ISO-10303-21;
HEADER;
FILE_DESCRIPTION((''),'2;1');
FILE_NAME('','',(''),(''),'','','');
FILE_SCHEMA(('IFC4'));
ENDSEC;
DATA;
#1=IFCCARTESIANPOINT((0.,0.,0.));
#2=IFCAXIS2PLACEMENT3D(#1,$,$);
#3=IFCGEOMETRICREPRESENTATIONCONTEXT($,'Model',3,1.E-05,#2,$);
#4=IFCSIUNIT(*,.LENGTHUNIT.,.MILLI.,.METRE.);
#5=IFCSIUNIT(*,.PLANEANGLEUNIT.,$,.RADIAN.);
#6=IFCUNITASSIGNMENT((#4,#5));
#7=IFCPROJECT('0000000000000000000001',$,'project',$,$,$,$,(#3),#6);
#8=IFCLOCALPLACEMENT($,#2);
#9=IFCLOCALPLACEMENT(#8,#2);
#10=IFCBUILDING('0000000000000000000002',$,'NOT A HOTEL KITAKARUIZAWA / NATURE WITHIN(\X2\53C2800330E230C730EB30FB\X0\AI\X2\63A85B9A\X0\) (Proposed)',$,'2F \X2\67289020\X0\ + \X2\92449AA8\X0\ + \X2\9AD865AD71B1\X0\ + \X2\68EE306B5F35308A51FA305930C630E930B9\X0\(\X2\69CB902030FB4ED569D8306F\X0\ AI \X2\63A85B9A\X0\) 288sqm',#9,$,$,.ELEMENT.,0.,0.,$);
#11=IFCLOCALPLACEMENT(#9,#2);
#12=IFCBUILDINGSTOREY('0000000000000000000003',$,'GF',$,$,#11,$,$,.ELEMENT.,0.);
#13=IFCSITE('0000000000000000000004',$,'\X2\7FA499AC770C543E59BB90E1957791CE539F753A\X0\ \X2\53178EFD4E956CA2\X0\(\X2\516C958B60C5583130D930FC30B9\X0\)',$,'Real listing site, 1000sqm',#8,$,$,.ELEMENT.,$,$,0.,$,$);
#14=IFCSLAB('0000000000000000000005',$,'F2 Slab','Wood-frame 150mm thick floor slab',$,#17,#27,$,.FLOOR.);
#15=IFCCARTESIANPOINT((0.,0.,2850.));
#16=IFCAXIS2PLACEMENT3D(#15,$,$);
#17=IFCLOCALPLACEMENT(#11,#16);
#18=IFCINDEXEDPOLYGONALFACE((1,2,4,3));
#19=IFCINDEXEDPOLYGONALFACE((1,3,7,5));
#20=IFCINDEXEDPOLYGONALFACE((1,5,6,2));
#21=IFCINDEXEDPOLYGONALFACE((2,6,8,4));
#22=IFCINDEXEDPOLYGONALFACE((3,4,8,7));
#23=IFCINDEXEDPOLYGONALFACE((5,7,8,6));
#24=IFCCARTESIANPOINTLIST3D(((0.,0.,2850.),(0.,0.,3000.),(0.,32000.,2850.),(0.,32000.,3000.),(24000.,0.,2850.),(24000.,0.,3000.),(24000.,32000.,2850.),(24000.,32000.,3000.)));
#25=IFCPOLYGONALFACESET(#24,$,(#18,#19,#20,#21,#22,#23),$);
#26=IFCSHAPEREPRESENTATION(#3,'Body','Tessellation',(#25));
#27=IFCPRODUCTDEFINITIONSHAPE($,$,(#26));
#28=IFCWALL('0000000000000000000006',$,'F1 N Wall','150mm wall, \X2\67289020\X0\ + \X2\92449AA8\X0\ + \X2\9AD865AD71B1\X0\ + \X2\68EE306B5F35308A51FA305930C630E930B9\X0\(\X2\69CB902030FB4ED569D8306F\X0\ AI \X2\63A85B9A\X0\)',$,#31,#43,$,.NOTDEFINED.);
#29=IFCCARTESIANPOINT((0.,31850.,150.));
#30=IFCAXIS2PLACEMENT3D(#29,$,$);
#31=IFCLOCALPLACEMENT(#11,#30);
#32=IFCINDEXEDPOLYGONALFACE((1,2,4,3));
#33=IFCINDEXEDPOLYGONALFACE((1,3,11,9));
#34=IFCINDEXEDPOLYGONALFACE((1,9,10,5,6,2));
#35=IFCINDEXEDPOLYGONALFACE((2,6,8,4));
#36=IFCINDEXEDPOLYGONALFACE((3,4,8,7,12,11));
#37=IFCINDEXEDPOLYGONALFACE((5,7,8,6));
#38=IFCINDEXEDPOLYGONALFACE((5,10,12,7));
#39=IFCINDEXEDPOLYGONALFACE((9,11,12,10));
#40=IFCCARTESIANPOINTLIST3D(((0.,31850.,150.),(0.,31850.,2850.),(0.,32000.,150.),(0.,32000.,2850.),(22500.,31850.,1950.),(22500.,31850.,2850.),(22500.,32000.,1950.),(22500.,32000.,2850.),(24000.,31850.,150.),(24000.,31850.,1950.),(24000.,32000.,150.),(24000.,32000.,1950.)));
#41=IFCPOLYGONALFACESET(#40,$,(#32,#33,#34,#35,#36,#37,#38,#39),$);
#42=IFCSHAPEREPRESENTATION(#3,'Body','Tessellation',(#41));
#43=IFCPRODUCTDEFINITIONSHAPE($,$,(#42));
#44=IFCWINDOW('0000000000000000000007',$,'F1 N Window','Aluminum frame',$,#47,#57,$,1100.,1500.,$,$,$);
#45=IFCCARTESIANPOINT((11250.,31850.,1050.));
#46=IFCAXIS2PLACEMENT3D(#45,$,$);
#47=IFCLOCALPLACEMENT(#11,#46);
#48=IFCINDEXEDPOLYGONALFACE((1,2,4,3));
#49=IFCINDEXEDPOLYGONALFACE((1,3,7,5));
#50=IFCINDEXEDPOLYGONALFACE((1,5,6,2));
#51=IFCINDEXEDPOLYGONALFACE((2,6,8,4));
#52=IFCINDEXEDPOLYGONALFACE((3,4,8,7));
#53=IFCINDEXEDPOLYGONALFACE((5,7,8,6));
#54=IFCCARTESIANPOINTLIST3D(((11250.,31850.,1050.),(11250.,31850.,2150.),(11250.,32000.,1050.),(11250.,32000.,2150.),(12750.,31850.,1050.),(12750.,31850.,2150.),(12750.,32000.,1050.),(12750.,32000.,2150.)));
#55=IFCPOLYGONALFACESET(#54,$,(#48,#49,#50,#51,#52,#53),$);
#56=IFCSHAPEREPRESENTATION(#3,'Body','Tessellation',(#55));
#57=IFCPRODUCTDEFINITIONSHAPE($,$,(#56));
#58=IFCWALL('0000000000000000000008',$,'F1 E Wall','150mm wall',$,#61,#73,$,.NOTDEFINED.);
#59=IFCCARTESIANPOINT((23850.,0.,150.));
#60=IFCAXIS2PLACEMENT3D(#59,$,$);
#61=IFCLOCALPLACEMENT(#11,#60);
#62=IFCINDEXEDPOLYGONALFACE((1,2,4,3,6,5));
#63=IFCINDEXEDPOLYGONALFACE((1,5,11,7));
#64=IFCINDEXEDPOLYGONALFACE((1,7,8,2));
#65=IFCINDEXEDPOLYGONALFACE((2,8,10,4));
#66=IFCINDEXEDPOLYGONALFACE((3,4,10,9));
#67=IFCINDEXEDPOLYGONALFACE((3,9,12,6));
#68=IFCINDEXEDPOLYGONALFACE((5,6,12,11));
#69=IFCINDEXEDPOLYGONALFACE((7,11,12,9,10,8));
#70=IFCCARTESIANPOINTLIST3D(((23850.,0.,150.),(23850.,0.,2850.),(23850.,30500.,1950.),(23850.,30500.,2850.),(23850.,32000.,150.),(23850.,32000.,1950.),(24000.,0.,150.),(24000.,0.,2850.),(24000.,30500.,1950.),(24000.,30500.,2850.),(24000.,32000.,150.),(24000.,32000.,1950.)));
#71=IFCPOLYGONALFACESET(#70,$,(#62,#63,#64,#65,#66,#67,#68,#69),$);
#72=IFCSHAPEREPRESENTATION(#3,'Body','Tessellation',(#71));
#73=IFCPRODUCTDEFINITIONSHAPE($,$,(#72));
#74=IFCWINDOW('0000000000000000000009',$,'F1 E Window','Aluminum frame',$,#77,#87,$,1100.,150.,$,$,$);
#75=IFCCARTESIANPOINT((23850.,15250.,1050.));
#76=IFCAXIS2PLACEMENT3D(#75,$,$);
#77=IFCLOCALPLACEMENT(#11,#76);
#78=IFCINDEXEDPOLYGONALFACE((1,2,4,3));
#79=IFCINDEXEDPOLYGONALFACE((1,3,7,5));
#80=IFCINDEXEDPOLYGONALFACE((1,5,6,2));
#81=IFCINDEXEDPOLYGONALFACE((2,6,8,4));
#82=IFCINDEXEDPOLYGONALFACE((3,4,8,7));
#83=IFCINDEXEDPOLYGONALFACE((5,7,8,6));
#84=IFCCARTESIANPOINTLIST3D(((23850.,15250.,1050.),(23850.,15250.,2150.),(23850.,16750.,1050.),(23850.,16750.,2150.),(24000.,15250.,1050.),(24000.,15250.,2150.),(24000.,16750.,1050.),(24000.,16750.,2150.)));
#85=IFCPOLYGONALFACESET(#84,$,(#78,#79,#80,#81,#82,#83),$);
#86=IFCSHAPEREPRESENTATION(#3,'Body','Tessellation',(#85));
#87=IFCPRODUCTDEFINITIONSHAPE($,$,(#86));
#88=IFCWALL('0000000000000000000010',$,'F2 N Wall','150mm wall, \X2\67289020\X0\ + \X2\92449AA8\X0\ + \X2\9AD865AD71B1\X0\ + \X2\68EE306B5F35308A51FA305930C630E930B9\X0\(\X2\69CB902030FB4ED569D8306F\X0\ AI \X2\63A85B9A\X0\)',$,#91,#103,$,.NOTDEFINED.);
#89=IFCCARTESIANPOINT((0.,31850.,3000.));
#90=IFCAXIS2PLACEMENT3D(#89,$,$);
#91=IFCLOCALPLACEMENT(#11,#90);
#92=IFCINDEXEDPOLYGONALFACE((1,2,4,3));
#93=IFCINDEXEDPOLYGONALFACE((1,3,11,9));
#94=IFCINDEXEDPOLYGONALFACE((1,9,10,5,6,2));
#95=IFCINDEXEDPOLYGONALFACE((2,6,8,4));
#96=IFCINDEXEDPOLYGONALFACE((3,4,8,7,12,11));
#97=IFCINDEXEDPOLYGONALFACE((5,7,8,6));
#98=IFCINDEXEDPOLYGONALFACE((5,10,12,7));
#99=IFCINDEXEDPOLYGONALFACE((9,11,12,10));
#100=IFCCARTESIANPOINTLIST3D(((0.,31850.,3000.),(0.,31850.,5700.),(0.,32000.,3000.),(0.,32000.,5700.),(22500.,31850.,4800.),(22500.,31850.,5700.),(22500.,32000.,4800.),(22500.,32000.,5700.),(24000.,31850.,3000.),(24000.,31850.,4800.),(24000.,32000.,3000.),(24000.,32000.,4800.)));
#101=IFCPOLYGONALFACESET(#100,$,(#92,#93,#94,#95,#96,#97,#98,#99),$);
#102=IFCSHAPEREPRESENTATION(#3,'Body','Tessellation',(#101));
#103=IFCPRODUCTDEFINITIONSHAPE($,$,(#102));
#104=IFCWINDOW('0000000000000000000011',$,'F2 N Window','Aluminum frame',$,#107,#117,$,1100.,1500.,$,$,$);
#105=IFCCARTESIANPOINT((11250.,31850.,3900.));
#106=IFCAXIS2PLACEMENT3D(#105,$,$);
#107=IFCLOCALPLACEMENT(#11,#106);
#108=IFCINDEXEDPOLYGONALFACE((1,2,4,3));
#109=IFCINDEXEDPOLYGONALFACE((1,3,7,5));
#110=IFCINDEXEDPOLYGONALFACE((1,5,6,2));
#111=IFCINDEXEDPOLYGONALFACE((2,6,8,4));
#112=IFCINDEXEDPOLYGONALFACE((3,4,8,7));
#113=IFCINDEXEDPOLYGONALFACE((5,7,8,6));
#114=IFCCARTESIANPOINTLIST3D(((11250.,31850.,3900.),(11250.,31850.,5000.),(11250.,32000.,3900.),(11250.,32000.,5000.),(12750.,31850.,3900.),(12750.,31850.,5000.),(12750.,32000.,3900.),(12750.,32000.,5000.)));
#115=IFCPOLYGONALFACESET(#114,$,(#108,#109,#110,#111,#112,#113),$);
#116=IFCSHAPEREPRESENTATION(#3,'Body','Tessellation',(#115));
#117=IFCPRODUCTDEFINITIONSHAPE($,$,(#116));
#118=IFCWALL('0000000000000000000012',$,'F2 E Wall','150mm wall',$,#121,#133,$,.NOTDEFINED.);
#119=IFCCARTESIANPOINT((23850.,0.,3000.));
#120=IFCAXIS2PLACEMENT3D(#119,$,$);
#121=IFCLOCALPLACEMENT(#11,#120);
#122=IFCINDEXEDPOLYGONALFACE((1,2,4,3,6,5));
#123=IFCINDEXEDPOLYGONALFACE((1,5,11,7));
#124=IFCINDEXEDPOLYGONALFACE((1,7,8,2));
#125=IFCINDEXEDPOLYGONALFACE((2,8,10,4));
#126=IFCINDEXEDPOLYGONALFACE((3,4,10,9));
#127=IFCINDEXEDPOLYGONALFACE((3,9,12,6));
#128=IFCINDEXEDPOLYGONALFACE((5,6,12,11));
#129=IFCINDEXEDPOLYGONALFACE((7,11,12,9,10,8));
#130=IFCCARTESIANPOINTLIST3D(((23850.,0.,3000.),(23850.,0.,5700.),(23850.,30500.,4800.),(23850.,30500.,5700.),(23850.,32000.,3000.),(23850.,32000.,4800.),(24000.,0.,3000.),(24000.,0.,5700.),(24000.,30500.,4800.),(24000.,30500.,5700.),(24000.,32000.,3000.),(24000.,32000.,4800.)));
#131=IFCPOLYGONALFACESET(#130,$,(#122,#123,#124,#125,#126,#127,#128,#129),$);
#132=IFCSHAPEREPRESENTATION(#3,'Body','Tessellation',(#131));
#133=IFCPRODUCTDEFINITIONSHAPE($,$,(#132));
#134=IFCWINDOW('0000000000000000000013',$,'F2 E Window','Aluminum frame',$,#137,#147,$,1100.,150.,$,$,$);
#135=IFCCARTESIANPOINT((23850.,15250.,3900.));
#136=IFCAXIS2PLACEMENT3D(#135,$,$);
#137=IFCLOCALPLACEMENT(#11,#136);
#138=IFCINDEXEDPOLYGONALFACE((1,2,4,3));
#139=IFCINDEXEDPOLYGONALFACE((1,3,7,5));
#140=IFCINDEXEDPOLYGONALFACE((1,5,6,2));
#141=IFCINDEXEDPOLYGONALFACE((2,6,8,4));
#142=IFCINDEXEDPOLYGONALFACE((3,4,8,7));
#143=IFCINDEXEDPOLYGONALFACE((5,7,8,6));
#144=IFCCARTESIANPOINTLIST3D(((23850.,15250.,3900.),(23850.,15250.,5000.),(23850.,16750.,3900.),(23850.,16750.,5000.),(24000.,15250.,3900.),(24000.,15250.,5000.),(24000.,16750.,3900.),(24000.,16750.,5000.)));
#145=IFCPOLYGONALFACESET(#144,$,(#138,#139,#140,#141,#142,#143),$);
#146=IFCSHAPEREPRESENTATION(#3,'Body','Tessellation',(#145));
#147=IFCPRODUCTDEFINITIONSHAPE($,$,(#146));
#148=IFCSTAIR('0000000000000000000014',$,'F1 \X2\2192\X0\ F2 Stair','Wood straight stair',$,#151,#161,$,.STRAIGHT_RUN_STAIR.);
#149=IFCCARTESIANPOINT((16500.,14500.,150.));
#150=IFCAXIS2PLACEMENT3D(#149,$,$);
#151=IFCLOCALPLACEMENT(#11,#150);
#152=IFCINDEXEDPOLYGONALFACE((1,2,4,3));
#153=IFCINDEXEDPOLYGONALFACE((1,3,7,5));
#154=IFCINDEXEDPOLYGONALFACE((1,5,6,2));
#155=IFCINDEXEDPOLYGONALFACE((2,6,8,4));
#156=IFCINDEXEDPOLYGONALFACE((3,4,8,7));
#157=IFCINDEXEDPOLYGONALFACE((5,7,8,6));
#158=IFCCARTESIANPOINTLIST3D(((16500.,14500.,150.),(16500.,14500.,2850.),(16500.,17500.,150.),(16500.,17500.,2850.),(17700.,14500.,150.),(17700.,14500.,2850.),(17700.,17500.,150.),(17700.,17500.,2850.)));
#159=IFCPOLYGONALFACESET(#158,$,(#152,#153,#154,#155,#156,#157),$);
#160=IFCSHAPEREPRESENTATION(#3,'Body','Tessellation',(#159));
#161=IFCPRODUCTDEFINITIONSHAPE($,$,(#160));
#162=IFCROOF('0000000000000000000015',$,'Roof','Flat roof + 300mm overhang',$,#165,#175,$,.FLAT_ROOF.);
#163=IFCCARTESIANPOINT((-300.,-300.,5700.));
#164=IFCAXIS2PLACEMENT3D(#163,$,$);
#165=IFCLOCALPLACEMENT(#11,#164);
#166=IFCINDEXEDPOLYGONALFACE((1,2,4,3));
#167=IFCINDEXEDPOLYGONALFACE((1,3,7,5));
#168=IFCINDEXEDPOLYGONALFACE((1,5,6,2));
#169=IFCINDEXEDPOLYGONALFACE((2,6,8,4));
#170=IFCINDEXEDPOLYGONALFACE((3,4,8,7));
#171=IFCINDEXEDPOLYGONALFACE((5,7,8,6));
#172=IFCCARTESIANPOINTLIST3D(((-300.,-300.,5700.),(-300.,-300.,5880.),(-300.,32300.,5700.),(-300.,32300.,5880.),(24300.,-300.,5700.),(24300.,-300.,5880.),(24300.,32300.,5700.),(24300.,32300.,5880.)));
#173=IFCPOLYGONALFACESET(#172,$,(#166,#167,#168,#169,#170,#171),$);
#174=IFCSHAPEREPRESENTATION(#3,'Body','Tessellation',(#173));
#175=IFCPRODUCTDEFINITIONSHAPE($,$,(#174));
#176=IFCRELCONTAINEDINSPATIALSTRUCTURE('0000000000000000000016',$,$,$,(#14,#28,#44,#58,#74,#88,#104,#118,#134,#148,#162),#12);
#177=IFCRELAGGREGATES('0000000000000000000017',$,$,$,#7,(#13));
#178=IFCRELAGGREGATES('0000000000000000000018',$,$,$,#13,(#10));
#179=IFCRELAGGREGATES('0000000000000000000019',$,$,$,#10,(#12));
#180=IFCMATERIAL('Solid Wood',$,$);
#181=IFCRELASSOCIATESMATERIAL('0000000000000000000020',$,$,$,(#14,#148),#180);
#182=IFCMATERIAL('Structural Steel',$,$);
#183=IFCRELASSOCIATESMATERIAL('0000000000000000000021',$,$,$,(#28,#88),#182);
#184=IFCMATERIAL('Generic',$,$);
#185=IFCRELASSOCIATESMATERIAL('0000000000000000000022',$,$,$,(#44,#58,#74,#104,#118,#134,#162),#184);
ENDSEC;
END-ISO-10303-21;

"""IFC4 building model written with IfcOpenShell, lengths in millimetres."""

from ifc_helpers import new_model, si_unit, frame, frame_2d, origin, place, context, project, spatial, rectangle, extrude, material, element, fill, save


model = new_model("IFC4")

# Units and contexts
model_context = context("Model", 3, precision=1e-05, world=origin())
ifc_project = project(units=[si_unit("LENGTHUNIT", "METRE", prefix="MILLI"), si_unit("PLANEANGLEUNIT", "RADIAN")], contexts=[model_context])

# Site, building, storey
site_placement = place(None, origin())
site = spatial("IfcSite", under=ifc_project, at=site_placement, Name="群馬県吾妻郡長野原町 北軽井沢(公開情報ベース)", ObjectType="Real listing site, 1000sqm", CompositionType="ELEMENT", RefElevation=0.0)
building_placement = place(site_placement, origin())
building = spatial("IfcBuilding", under=site, at=building_placement, Name="NOT A HOTEL KITAKARUIZAWA / NATURE WITHIN(参考モデル・AI推定) (Proposed)", ObjectType="2F 木造 + 鉄骨 + 高断熱 + 森に張り出すテラス(構造・仕様は AI 推定) 288sqm", CompositionType="ELEMENT", ElevationOfRefHeight=0.0, ElevationOfTerrain=0.0)
storey_placement = place(building_placement, origin())
storey = spatial("IfcBuildingStorey", under=building, at=storey_placement, Name="GF", CompositionType="ELEMENT", Elevation=0.0)

# Slab
ifc_material_1 = material(Name="Solid Wood")
slab_1_placement = place(storey_placement, frame((0.0, 0.0, 2850.0)))
element("IfcSlab", 1, at=slab_1_placement, inside=storey, material=ifc_material_1, Name="F2 Slab", Description="Wood-frame 150mm thick floor slab", PredefinedType="FLOOR", context=model_context, shape_type="SweptSolid", body=[
    extrude(rectangle(XDim=24000.0, YDim=32000.0, at=frame_2d((12000.0, 16000.0))), frame((0.0, 0.0, 2850.0)), (0.0, 0.0, 1.0), 150.0),
])

# Wall, opening, window
ifc_material_2 = material(Name="Structural Steel")
wall_1_placement = place(storey_placement, frame((0.0, 31850.0, 150.0)))
wall_1 = element("IfcWall", 2, at=wall_1_placement, inside=storey, material=ifc_material_2, Name="F1 N Wall", Description="150mm wall, 木造 + 鉄骨 + 高断熱 + 森に張り出すテラス(構造・仕様は AI 推定)", PredefinedType="NOTDEFINED", context=model_context, shape_type="SweptSolid", body=[
    extrude(rectangle(XDim=24000.0, YDim=150.0, at=frame_2d((12000.0, 75.0))), frame((0.0, 31850.0, 150.0)), (0.0, 0.0, 1.0), 2700.0),
])
opening_1_placement = place(storey_placement, frame((11250.0, 31850.0, 1050.0)))
opening_1 = element("IfcOpeningElement", 3, at=opening_1_placement, cuts=wall_1, PredefinedType="NOTDEFINED", context=model_context, shape_type="SweptSolid", body=[
    extrude(rectangle(XDim=1500.0, YDim=150.0, at=frame_2d((750.0, 75.0))), frame((11250.0, 31850.0, 1050.0)), (0.0, 0.0, 1.0), 1100.0),
])
ifc_material_3 = material(Name="Generic")
window_1_placement = place(storey_placement, frame((11250.0, 31850.0, 1050.0)))
window_1 = element("IfcWindow", 4, at=window_1_placement, inside=storey, material=ifc_material_3, Name="F1 N Window", Description="Aluminum frame", OverallHeight=1100.0, OverallWidth=1500.0, context=model_context, shape_type="SweptSolid", body=[
    extrude(rectangle(XDim=1500.0, YDim=150.0, at=frame_2d((750.0, 75.0))), frame((11250.0, 31850.0, 1050.0)), (0.0, 0.0, 1.0), 1100.0),
])
fill(opening_1, window_1)

# Walls, openings, windows
wall_2_placement = place(storey_placement, frame((23850.0, 0.0, 150.0)))
wall_2 = element("IfcWall", 5, at=wall_2_placement, inside=storey, material=ifc_material_3, Name="F1 E Wall", Description="150mm wall", PredefinedType="NOTDEFINED", context=model_context, shape_type="SweptSolid", body=[
    extrude(rectangle(XDim=150.0, YDim=32000.0, at=frame_2d((75.0, 16000.0))), frame((23850.0, 0.0, 150.0)), (0.0, 0.0, 1.0), 2700.0),
])
opening_2_placement = place(storey_placement, frame((23850.0, 15250.0, 1050.0)))
opening_2 = element("IfcOpeningElement", 6, at=opening_2_placement, cuts=wall_2, PredefinedType="NOTDEFINED", context=model_context, shape_type="SweptSolid", body=[
    extrude(rectangle(XDim=150.0, YDim=1500.0, at=frame_2d((75.0, 750.0))), frame((23850.0, 15250.0, 1050.0)), (0.0, 0.0, 1.0), 1100.0),
])
window_2_placement = place(storey_placement, frame((23850.0, 15250.0, 1050.0)))
window_2 = element("IfcWindow", 7, at=window_2_placement, inside=storey, material=ifc_material_3, Name="F1 E Window", Description="Aluminum frame", OverallHeight=1100.0, OverallWidth=150.0, context=model_context, shape_type="SweptSolid", body=[
    extrude(rectangle(XDim=150.0, YDim=1500.0, at=frame_2d((75.0, 750.0))), frame((23850.0, 15250.0, 1050.0)), (0.0, 0.0, 1.0), 1100.0),
])
fill(opening_2, window_2)
wall_3_placement = place(storey_placement, frame((0.0, 31850.0, 3000.0)))
wall_3 = element("IfcWall", 8, at=wall_3_placement, inside=storey, material=ifc_material_2, Name="F2 N Wall", Description="150mm wall, 木造 + 鉄骨 + 高断熱 + 森に張り出すテラス(構造・仕様は AI 推定)", PredefinedType="NOTDEFINED", context=model_context, shape_type="SweptSolid", body=[
    extrude(rectangle(XDim=24000.0, YDim=150.0, at=frame_2d((12000.0, 75.0))), frame((0.0, 31850.0, 3000.0)), (0.0, 0.0, 1.0), 2700.0),
])
opening_3_placement = place(storey_placement, frame((11250.0, 31850.0, 3900.0)))
opening_3 = element("IfcOpeningElement", 9, at=opening_3_placement, cuts=wall_3, PredefinedType="NOTDEFINED", context=model_context, shape_type="SweptSolid", body=[
    extrude(rectangle(XDim=1500.0, YDim=150.0, at=frame_2d((750.0, 75.0))), frame((11250.0, 31850.0, 3900.0)), (0.0, 0.0, 1.0), 1100.0),
])
window_3_placement = place(storey_placement, frame((11250.0, 31850.0, 3900.0)))
window_3 = element("IfcWindow", 10, at=window_3_placement, inside=storey, material=ifc_material_3, Name="F2 N Window", Description="Aluminum frame", OverallHeight=1100.0, OverallWidth=1500.0, context=model_context, shape_type="SweptSolid", body=[
    extrude(rectangle(XDim=1500.0, YDim=150.0, at=frame_2d((750.0, 75.0))), frame((11250.0, 31850.0, 3900.0)), (0.0, 0.0, 1.0), 1100.0),
])
fill(opening_3, window_3)
wall_4_placement = place(storey_placement, frame((23850.0, 0.0, 3000.0)))
wall_4 = element("IfcWall", 11, at=wall_4_placement, inside=storey, material=ifc_material_3, Name="F2 E Wall", Description="150mm wall", PredefinedType="NOTDEFINED", context=model_context, shape_type="SweptSolid", body=[
    extrude(rectangle(XDim=150.0, YDim=32000.0, at=frame_2d((75.0, 16000.0))), frame((23850.0, 0.0, 3000.0)), (0.0, 0.0, 1.0), 2700.0),
])
opening_4_placement = place(storey_placement, frame((23850.0, 15250.0, 3900.0)))
opening_4 = element("IfcOpeningElement", 12, at=opening_4_placement, cuts=wall_4, PredefinedType="NOTDEFINED", context=model_context, shape_type="SweptSolid", body=[
    extrude(rectangle(XDim=150.0, YDim=1500.0, at=frame_2d((75.0, 750.0))), frame((23850.0, 15250.0, 3900.0)), (0.0, 0.0, 1.0), 1100.0),
])
window_4_placement = place(storey_placement, frame((23850.0, 15250.0, 3900.0)))
window_4 = element("IfcWindow", 13, at=window_4_placement, inside=storey, material=ifc_material_3, Name="F2 E Window", Description="Aluminum frame", OverallHeight=1100.0, OverallWidth=150.0, context=model_context, shape_type="SweptSolid", body=[
    extrude(rectangle(XDim=150.0, YDim=1500.0, at=frame_2d((75.0, 750.0))), frame((23850.0, 15250.0, 3900.0)), (0.0, 0.0, 1.0), 1100.0),
])
fill(opening_4, window_4)

# Stair
stair_placement = place(storey_placement, frame((16500.0, 14500.0, 150.0)))
element("IfcStair", 14, at=stair_placement, inside=storey, material=ifc_material_1, Name="F1 → F2 Stair", Description="Wood straight stair", PredefinedType="STRAIGHT_RUN_STAIR", context=model_context, shape_type="SweptSolid", body=[
    extrude(rectangle(XDim=1200.0, YDim=3000.0, at=frame_2d((600.0, 1500.0))), frame((16500.0, 14500.0, 150.0)), (0.0, 0.0, 1.0), 2700.0),
])

# Roof
roof_placement = place(storey_placement, frame((-300.0, -300.0, 5700.0)))
element("IfcRoof", 15, at=roof_placement, inside=storey, material=ifc_material_3, Name="Roof", Description="Flat roof + 300mm overhang", PredefinedType="FLAT_ROOF", context=model_context, shape_type="SweptSolid", body=[
    extrude(rectangle(XDim=24600.0, YDim=32600.0, at=frame_2d((12300.0, 16300.0))), frame((-300.0, -300.0, 5700.0)), (0.0, 0.0, 1.0), 180.0),
])

save(model, "model.ifc")
